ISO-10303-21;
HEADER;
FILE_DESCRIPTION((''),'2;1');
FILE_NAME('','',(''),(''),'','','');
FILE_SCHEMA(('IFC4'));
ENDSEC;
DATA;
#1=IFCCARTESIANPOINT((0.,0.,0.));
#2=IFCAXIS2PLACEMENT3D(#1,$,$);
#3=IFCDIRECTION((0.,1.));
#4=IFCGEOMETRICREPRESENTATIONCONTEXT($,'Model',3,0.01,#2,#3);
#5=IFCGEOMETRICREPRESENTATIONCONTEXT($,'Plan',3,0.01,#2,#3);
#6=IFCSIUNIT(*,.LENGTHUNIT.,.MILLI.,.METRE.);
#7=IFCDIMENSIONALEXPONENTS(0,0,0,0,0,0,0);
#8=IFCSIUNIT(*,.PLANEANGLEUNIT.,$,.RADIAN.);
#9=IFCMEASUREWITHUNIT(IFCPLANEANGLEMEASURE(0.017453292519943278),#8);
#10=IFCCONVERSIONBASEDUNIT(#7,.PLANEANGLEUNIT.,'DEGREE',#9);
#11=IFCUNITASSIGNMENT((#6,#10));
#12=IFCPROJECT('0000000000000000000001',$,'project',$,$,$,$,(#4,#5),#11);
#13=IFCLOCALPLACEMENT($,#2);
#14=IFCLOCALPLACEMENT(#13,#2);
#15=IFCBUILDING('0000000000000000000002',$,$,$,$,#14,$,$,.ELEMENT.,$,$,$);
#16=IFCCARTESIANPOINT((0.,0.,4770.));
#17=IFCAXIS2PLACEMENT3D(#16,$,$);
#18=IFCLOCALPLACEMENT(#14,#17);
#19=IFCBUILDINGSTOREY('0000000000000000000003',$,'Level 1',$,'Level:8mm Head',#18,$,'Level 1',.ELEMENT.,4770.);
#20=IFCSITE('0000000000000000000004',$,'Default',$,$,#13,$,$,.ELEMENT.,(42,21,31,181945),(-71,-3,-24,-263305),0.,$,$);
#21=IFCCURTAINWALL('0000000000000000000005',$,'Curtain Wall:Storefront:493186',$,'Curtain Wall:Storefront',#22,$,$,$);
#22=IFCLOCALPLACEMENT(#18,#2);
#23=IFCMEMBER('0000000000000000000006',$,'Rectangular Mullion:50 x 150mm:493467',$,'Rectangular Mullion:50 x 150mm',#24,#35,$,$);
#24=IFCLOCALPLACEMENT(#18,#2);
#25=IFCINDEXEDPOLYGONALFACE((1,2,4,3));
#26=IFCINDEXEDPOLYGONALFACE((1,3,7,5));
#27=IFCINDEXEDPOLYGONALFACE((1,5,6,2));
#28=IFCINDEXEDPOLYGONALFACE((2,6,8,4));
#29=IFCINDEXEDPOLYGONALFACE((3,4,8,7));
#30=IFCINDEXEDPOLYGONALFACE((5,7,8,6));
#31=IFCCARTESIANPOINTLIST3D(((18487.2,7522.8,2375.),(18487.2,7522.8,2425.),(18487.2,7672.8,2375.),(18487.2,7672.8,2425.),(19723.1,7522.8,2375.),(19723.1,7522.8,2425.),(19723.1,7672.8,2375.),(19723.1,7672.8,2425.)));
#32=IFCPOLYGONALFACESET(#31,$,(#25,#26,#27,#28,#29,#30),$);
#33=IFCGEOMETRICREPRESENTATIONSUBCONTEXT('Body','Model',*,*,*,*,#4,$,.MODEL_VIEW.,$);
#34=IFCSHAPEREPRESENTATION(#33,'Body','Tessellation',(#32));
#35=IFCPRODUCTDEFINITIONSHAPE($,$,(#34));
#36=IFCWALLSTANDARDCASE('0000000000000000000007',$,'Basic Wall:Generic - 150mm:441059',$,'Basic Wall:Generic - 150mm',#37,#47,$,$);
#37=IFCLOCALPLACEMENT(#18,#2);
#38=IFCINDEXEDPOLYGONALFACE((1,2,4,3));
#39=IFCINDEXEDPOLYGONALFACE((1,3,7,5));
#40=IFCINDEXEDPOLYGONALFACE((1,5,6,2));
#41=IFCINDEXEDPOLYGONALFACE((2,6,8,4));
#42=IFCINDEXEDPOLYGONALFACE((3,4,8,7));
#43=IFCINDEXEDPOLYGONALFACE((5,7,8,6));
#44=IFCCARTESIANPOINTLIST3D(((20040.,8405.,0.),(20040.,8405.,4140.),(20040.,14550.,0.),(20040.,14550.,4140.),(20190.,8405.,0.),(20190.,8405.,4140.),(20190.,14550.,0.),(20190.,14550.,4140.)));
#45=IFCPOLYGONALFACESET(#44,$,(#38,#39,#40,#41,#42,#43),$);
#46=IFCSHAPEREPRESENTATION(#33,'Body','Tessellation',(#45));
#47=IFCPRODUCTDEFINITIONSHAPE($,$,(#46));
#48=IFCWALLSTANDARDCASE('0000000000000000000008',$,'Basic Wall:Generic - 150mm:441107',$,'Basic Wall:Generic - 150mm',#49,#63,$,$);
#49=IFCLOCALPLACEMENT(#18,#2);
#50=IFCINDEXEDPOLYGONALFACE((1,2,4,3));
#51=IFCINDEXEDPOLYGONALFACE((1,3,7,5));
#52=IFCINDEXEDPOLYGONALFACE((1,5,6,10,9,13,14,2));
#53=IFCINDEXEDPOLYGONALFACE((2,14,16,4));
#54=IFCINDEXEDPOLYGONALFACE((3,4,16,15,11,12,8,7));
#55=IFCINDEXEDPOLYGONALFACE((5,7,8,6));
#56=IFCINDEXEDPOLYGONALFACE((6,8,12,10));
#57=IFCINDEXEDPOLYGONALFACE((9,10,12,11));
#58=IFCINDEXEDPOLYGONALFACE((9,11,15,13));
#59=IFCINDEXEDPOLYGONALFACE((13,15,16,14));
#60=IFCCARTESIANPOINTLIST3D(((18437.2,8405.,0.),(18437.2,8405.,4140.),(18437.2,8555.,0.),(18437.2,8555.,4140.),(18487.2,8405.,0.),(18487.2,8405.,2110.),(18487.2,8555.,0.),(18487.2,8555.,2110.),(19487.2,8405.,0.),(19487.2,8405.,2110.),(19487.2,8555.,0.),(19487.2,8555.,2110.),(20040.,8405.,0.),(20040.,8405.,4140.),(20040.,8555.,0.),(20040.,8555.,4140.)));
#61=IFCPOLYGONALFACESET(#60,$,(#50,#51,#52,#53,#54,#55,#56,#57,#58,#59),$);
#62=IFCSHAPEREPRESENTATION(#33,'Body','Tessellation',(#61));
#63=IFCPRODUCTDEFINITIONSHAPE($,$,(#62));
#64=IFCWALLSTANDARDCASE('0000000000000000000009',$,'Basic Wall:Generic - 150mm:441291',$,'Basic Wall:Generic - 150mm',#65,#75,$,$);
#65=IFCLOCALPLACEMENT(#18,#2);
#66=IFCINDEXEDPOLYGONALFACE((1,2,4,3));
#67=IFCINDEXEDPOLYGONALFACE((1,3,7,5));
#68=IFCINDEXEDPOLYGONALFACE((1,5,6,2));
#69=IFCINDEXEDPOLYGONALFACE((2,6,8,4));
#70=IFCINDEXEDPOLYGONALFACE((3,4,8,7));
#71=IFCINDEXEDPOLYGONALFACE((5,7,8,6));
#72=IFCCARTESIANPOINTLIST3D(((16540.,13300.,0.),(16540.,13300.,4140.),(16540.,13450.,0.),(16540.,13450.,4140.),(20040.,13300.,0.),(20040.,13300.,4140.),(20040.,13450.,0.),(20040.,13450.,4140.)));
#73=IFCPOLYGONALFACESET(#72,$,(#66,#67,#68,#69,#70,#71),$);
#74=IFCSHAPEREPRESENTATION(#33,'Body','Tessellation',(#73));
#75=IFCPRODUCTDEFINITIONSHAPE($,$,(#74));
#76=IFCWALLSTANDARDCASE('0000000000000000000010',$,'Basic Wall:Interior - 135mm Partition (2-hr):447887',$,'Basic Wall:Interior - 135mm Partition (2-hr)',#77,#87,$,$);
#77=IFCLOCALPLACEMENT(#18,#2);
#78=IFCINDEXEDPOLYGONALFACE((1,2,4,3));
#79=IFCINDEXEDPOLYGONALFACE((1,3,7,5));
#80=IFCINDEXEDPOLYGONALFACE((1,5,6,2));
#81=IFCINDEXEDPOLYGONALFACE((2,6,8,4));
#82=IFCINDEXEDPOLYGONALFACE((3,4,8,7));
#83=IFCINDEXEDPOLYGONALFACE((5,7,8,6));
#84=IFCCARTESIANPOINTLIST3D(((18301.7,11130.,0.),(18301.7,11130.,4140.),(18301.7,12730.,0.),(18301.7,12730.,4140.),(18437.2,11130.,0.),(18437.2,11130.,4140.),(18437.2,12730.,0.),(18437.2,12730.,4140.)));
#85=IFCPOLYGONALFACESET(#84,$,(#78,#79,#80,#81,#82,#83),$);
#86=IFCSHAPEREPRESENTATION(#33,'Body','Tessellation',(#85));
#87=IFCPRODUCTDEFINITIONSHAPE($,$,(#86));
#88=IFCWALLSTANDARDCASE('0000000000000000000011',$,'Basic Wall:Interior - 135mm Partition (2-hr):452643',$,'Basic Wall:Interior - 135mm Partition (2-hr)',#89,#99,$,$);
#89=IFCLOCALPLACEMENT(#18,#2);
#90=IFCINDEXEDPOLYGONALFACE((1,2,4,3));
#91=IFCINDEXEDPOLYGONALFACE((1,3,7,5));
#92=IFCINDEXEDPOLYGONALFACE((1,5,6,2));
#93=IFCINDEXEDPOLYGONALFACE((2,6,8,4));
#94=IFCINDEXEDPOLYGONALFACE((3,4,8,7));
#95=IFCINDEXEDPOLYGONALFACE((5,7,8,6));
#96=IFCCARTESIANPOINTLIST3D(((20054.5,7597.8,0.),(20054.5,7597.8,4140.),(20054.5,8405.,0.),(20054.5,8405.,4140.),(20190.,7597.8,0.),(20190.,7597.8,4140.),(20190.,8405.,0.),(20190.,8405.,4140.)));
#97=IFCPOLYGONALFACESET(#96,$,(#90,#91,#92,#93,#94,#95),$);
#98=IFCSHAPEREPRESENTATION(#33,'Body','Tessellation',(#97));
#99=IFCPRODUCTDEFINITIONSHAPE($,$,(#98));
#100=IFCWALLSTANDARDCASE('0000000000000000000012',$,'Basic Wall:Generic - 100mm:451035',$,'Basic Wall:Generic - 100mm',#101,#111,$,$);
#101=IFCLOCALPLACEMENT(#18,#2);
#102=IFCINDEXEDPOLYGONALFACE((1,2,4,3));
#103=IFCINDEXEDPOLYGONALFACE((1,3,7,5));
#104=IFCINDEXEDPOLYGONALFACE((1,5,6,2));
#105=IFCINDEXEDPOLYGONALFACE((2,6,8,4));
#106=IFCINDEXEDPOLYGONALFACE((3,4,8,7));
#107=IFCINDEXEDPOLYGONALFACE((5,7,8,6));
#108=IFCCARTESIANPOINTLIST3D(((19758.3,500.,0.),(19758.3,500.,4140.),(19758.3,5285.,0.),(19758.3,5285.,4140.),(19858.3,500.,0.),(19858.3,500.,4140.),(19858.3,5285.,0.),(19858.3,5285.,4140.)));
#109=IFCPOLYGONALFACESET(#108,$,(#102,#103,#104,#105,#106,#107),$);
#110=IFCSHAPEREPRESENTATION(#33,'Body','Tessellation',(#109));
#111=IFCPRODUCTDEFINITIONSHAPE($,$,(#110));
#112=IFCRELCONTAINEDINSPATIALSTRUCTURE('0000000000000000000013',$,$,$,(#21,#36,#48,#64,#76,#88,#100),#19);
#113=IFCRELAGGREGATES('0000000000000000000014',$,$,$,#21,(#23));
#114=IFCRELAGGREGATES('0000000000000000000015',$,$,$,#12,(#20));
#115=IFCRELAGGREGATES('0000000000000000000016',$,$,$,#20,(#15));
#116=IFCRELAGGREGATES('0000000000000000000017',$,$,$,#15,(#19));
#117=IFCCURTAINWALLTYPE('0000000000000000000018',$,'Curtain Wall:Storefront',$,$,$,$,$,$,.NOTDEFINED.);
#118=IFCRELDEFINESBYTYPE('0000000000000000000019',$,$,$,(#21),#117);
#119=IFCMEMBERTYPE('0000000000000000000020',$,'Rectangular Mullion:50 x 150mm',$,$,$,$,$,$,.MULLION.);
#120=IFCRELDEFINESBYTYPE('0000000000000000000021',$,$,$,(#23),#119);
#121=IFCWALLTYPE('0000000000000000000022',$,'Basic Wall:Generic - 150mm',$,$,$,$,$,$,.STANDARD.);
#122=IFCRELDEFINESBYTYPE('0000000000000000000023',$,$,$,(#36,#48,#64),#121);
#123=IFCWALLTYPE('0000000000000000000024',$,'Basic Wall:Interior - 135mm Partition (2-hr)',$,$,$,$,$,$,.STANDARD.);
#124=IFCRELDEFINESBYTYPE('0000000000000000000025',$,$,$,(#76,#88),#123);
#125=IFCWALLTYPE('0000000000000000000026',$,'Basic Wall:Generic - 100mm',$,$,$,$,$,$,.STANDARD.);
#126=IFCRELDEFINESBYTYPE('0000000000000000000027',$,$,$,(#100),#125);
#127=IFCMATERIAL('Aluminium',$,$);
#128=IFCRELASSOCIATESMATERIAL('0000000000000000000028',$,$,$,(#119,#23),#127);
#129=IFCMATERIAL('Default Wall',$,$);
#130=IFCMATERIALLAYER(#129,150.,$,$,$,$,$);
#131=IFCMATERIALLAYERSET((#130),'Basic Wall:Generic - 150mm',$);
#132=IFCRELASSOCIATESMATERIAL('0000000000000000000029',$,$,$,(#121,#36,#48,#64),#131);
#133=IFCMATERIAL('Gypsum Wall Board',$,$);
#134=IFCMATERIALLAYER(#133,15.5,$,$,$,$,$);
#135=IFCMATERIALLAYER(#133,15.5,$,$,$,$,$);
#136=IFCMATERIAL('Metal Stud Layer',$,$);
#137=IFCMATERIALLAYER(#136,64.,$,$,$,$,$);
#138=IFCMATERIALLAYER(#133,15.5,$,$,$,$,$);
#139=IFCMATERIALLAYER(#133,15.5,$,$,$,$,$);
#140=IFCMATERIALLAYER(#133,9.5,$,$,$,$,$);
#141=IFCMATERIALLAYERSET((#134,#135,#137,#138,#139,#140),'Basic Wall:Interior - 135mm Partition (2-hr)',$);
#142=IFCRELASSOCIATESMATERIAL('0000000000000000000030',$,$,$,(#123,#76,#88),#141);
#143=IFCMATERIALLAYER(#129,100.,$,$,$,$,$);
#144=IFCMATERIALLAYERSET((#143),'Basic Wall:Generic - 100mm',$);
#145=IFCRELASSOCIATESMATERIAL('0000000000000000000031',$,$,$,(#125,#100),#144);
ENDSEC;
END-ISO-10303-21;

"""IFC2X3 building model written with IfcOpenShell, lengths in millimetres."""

from ifc_helpers import new_model, entity, si_unit, converted_unit, direction, frame, frame_2d, origin, origin_2d_with_axis, place, context, subcontext, project, spatial, polyline, rectangle, extrude, clip, bounded_halfspace, source, transform, mapped, material, layer, layer_set, layer_usage, type_object, type_shapes, element, aggregate, save


model = new_model("IFC2X3")

# Units and contexts
model_context = context("Model", 3, precision=0.01, world=origin(), true_north=direction((0.0, 1.0)))
plan_context = context("Plan", 3, precision=0.01, world=origin(), true_north=direction((0.0, 1.0)))
body_context = subcontext(model_context, "Body", "Model", "MODEL_VIEW")
ifc_project = project(units=[si_unit("LENGTHUNIT", "METRE", prefix="MILLI"), converted_unit("PLANEANGLEUNIT", "DEGREE", entity("IfcPlaneAngleMeasure", 0.017453292519943278), si_unit("PLANEANGLEUNIT", "RADIAN"), dimensions=[0, 0, 0, 0, 0, 0, 0])], contexts=[model_context, plan_context])

# Site, building, storey
site_placement = place(None, origin())
site = spatial("IfcSite", under=ifc_project, at=site_placement, Name="Default", CompositionType="ELEMENT", RefLatitude=(42, 21, 31, 181945), RefLongitude=(-71, -3, -24, -263305), RefElevation=0.0)
building_placement = place(site_placement, origin())
building = spatial("IfcBuilding", under=site, at=building_placement, CompositionType="ELEMENT")
storey_placement = place(building_placement, frame((0.0, 0.0, 4770.0)))
storey = spatial("IfcBuildingStorey", under=building, at=storey_placement, Name="Level 1", ObjectType="Level:8mm Head", LongName="Level 1", CompositionType="ELEMENT", Elevation=4770.0)

# Curtain wall
curtain_wall_type = type_object("IfcCurtainWallType", Name="Curtain Wall:Storefront", PredefinedType="NOTDEFINED")
curtain_wall_1_placement = place(storey_placement, frame((0.0, 0.0, -4770.0)))
curtain_wall_1 = element("IfcCurtainWall", 1, at=curtain_wall_1_placement, inside=storey, type_object=curtain_wall_type, Name="Curtain Wall:Storefront:493186", ObjectType="Curtain Wall:Storefront")
ifc_material_1 = material(Name="Aluminium")

# Member
member_type_1 = type_object("IfcMemberType", Name="Rectangular Mullion:50 x 150mm", PredefinedType="MULLION", material=ifc_material_1)
shared_shape_1 = source(origin(), body_context, "Body", "SweptSolid", [
    extrude(rectangle(XDim=50.0, YDim=150.0, at=origin_2d_with_axis()), frame((0.0, 0.0, -1236.0), z_axis=(0.0, 0.0, 1.0), x_axis=(-1.0, 0.0, 0.0)), (0.0, 0.0, 1.0), 1236.0),
])
type_shapes(member_type_1, [shared_shape_1])
member_1_placement = place(curtain_wall_1_placement, frame((18487.2, 7597.8, 7170.0), z_axis=(-1.0, 0.0, 0.0), x_axis=(0.0, 0.0, 1.0)))
member_1 = element("IfcMember", 2, at=member_1_placement, type_object=member_type_1, material=ifc_material_1, Name="Rectangular Mullion:50 x 150mm:493467", ObjectType="Rectangular Mullion:50 x 150mm", context=body_context, shape_type="MappedRepresentation", body=[
    mapped(shared_shape_1, transform((0.0, 0.0, 0.0), scale=1.0)),
])

aggregate(curtain_wall_1, [member_1])

# Wall
ifc_material_2 = material(Name="Default Wall")
ifc_layer_1 = layer(ifc_material_2, 150.0)
ifc_layer_set_1 = layer_set([ifc_layer_1], Name="Basic Wall:Generic - 150mm")
ifc_layer_usage_1 = layer_usage(ifc_layer_set_1, "AXIS2", "POSITIVE", -75.0)
wall_type_1 = type_object("IfcWallType", Name="Basic Wall:Generic - 150mm", PredefinedType="STANDARD", material=ifc_layer_set_1)
wall_1_placement = place(storey_placement, frame((20115.0, 14550.0, 0.0), z_axis=(0.0, 0.0, 1.0), x_axis=(0.0, -1.0, 0.0)))
element("IfcWallStandardCase", 3, at=wall_1_placement, inside=storey, type_object=wall_type_1, material=ifc_layer_usage_1, Name="Basic Wall:Generic - 150mm:441059", ObjectType="Basic Wall:Generic - 150mm", context=body_context, shape_type="Clipping", body=[
    clip(extrude(rectangle(XDim=6145.0, YDim=150.0, at=frame_2d((3072.5, 0.0), x_axis=(-1.0, 0.0))), origin(), (0.0, 0.0, 1.0), 4140.0), bounded_halfspace(frame((0.0, -75.0, 4140.0), z_axis=(0.0, 0.0, -1.0), x_axis=(1.0, 0.0, 0.0)), True, frame((0.0, -75.0, 4140.0)), polyline([(0.0, 0.0), (1100.0, 0.0), (1250.0, 0.0), (5995.0, 0.0), (6145.0, 0.0), (6145.0, 14.5), (6145.0, 150.0), (0.0, 150.0), (0.0, 0.0)]))),
])

# Wall, opening
wall_2_placement = place(storey_placement, frame((20040.0, 8480.0, 0.0), z_axis=(0.0, 0.0, 1.0), x_axis=(-1.0, 0.0, 0.0)))
wall_2 = element("IfcWallStandardCase", 4, at=wall_2_placement, inside=storey, type_object=wall_type_1, material=ifc_layer_usage_1, Name="Basic Wall:Generic - 150mm:441107", ObjectType="Basic Wall:Generic - 150mm", context=body_context, shape_type="Clipping", body=[
    clip(extrude(rectangle(XDim=1602.8, YDim=150.0, at=frame_2d((801.4, 0.0), x_axis=(1.0, 0.0))), origin(), (0.0, 0.0, 1.0), 4140.0), bounded_halfspace(frame((0.0, -75.0, 4140.0), z_axis=(0.0, 0.0, -1.0), x_axis=(0.0, 1.0, 0.0)), True, frame((0.0, -75.0, 4140.0)), polyline([(0.0, 0.0), (1602.8, 0.0), (1602.8, 150.0), (0.0, 150.0), (0.0, 0.0)]))),
])
opening_placement = place(wall_2_placement, frame((1552.8, 75.0, 0.0)))
element("IfcOpeningElement", 5, at=opening_placement, cuts=wall_2, ObjectType="Opening", context=body_context, shape_type="SweptSolid", body=[
    extrude(rectangle(XDim=2110.0, YDim=1000.0, at=frame_2d((1055.0, 500.0), x_axis=(1.0, 0.0))), frame((0.0, 0.0, 0.0), z_axis=(0.0, -1.0, 0.0), x_axis=(0.0, 0.0, 1.0)), (0.0, 0.0, 1.0), 150.0),
])

# Walls
wall_3_placement = place(storey_placement, frame((20040.0, 13375.0, 0.0), z_axis=(0.0, 0.0, 1.0), x_axis=(-1.0, 0.0, 0.0)))
element("IfcWallStandardCase", 6, at=wall_3_placement, inside=storey, type_object=wall_type_1, material=ifc_layer_usage_1, Name="Basic Wall:Generic - 150mm:441291", ObjectType="Basic Wall:Generic - 150mm", context=body_context, shape_type="Clipping", body=[
    clip(extrude(rectangle(XDim=3500.0, YDim=150.0, at=frame_2d((1750.0, 0.0), x_axis=(-1.0, 0.0))), origin(), (0.0, 0.0, 1.0), 4140.0), bounded_halfspace(frame((0.0, -75.0, 4140.0), z_axis=(0.0, 0.0, -1.0), x_axis=(0.0, 1.0, 0.0)), True, frame((0.0, -75.0, 4140.0)), polyline([(0.0, 0.0), (3500.0, 0.0), (3500.0, 150.0), (2598.3, 150.0), (2462.8, 150.0), (0.0, 150.0), (0.0, 0.0)]))),
])
ifc_material_3 = material(Name="Gypsum Wall Board")
ifc_layer_2 = layer(ifc_material_3, 15.5)
ifc_layer_3 = layer(ifc_material_3, 15.5)
ifc_material_4 = material(Name="Metal Stud Layer")
ifc_layer_4 = layer(ifc_material_4, 64.0)
ifc_layer_5 = layer(ifc_material_3, 15.5)
ifc_layer_6 = layer(ifc_material_3, 15.5)
ifc_layer_7 = layer(ifc_material_3, 9.5)
ifc_layer_set_2 = layer_set([ifc_layer_2, ifc_layer_3, ifc_layer_4, ifc_layer_5, ifc_layer_6, ifc_layer_7], Name="Basic Wall:Interior - 135mm Partition (2-hr)")
ifc_layer_usage_2 = layer_usage(ifc_layer_set_2, "AXIS2", "POSITIVE", -67.8)
wall_type_2 = type_object("IfcWallType", Name="Basic Wall:Interior - 135mm Partition (2-hr)", PredefinedType="STANDARD", material=ifc_layer_set_2)
wall_4_placement = place(storey_placement, frame((18369.4, 11130.0, 0.0), z_axis=(0.0, 0.0, 1.0), x_axis=(0.0, 1.0, 0.0)))
element("IfcWallStandardCase", 7, at=wall_4_placement, inside=storey, type_object=wall_type_2, material=ifc_layer_usage_2, Name="Basic Wall:Interior - 135mm Partition (2-hr):447887", ObjectType="Basic Wall:Interior - 135mm Partition (2-hr)", context=body_context, shape_type="Clipping", body=[
    clip(extrude(rectangle(XDim=1600.0, YDim=135.5, at=frame_2d((800.0, 0.0), x_axis=(-1.0, 0.0))), origin(), (0.0, 0.0, 1.0), 4140.0), bounded_halfspace(frame((0.0, -67.7, 4140.0), z_axis=(0.0, 0.0, -1.0), x_axis=(-1.0, 0.0, 0.0)), True, frame((0.0, -67.7, 4140.0)), polyline([(0.0, 0.0), (1600.0, 0.0), (1600.0, 135.5), (855.5, 135.5), (720.0, 135.5), (0.0, 135.5), (0.0, 0.0)]))),
])
ifc_layer_usage_3 = layer_usage(ifc_layer_set_2, "AXIS2", "NEGATIVE", 67.8)
wall_5_placement = place(storey_placement, frame((20122.3, 8405.0, 0.0), z_axis=(0.0, 0.0, 1.0), x_axis=(0.0, -1.0, 0.0)))
element("IfcWallStandardCase", 8, at=wall_5_placement, inside=storey, type_object=wall_type_2, material=ifc_layer_usage_3, Name="Basic Wall:Interior - 135mm Partition (2-hr):452643", ObjectType="Basic Wall:Interior - 135mm Partition (2-hr)", context=body_context, shape_type="Clipping", body=[
    clip(extrude(rectangle(XDim=807.2, YDim=135.5, at=frame_2d((403.6, 0.0), x_axis=(-1.0, 0.0))), origin(), (0.0, 0.0, 1.0), 4140.0), bounded_halfspace(frame((0.0, -67.7, 4140.0), z_axis=(0.0, 0.0, -1.0), x_axis=(1.0, 0.0, 0.0)), True, frame((0.0, -67.7, 4140.0)), polyline([(0.0, 0.0), (807.2, 0.0), (807.2, 135.5), (0.0, 135.5), (0.0, 0.0)]))),
])
ifc_layer_8 = layer(ifc_material_2, 100.0)
ifc_layer_set_3 = layer_set([ifc_layer_8], Name="Basic Wall:Generic - 100mm")
ifc_layer_usage_4 = layer_usage(ifc_layer_set_3, "AXIS2", "NEGATIVE", 50.0)
wall_type_3 = type_object("IfcWallType", Name="Basic Wall:Generic - 100mm", PredefinedType="STANDARD", material=ifc_layer_set_3)
wall_6_placement = place(storey_placement, frame((19808.3, 5285.0, 0.0), z_axis=(0.0, 0.0, 1.0), x_axis=(0.0, -1.0, 0.0)))
element("IfcWallStandardCase", 9, at=wall_6_placement, inside=storey, type_object=wall_type_3, material=ifc_layer_usage_4, Name="Basic Wall:Generic - 100mm:451035", ObjectType="Basic Wall:Generic - 100mm", context=body_context, shape_type="Clipping", body=[
    clip(extrude(rectangle(XDim=4785.0, YDim=100.0, at=frame_2d((2392.5, 0.0), x_axis=(-1.0, 0.0))), origin(), (0.0, 0.0, 1.0), 4140.0), bounded_halfspace(frame((0.0, -50.0, 4140.0), z_axis=(0.0, 0.0, -1.0), x_axis=(1.0, 0.0, 0.0)), True, frame((0.0, -50.0, 4140.0)), polyline([(0.0, 0.0), (4785.0, 0.0), (4785.0, 100.0), (0.0, 100.0), (0.0, 0.0)]))),
])

save(model, "model.ifc")
